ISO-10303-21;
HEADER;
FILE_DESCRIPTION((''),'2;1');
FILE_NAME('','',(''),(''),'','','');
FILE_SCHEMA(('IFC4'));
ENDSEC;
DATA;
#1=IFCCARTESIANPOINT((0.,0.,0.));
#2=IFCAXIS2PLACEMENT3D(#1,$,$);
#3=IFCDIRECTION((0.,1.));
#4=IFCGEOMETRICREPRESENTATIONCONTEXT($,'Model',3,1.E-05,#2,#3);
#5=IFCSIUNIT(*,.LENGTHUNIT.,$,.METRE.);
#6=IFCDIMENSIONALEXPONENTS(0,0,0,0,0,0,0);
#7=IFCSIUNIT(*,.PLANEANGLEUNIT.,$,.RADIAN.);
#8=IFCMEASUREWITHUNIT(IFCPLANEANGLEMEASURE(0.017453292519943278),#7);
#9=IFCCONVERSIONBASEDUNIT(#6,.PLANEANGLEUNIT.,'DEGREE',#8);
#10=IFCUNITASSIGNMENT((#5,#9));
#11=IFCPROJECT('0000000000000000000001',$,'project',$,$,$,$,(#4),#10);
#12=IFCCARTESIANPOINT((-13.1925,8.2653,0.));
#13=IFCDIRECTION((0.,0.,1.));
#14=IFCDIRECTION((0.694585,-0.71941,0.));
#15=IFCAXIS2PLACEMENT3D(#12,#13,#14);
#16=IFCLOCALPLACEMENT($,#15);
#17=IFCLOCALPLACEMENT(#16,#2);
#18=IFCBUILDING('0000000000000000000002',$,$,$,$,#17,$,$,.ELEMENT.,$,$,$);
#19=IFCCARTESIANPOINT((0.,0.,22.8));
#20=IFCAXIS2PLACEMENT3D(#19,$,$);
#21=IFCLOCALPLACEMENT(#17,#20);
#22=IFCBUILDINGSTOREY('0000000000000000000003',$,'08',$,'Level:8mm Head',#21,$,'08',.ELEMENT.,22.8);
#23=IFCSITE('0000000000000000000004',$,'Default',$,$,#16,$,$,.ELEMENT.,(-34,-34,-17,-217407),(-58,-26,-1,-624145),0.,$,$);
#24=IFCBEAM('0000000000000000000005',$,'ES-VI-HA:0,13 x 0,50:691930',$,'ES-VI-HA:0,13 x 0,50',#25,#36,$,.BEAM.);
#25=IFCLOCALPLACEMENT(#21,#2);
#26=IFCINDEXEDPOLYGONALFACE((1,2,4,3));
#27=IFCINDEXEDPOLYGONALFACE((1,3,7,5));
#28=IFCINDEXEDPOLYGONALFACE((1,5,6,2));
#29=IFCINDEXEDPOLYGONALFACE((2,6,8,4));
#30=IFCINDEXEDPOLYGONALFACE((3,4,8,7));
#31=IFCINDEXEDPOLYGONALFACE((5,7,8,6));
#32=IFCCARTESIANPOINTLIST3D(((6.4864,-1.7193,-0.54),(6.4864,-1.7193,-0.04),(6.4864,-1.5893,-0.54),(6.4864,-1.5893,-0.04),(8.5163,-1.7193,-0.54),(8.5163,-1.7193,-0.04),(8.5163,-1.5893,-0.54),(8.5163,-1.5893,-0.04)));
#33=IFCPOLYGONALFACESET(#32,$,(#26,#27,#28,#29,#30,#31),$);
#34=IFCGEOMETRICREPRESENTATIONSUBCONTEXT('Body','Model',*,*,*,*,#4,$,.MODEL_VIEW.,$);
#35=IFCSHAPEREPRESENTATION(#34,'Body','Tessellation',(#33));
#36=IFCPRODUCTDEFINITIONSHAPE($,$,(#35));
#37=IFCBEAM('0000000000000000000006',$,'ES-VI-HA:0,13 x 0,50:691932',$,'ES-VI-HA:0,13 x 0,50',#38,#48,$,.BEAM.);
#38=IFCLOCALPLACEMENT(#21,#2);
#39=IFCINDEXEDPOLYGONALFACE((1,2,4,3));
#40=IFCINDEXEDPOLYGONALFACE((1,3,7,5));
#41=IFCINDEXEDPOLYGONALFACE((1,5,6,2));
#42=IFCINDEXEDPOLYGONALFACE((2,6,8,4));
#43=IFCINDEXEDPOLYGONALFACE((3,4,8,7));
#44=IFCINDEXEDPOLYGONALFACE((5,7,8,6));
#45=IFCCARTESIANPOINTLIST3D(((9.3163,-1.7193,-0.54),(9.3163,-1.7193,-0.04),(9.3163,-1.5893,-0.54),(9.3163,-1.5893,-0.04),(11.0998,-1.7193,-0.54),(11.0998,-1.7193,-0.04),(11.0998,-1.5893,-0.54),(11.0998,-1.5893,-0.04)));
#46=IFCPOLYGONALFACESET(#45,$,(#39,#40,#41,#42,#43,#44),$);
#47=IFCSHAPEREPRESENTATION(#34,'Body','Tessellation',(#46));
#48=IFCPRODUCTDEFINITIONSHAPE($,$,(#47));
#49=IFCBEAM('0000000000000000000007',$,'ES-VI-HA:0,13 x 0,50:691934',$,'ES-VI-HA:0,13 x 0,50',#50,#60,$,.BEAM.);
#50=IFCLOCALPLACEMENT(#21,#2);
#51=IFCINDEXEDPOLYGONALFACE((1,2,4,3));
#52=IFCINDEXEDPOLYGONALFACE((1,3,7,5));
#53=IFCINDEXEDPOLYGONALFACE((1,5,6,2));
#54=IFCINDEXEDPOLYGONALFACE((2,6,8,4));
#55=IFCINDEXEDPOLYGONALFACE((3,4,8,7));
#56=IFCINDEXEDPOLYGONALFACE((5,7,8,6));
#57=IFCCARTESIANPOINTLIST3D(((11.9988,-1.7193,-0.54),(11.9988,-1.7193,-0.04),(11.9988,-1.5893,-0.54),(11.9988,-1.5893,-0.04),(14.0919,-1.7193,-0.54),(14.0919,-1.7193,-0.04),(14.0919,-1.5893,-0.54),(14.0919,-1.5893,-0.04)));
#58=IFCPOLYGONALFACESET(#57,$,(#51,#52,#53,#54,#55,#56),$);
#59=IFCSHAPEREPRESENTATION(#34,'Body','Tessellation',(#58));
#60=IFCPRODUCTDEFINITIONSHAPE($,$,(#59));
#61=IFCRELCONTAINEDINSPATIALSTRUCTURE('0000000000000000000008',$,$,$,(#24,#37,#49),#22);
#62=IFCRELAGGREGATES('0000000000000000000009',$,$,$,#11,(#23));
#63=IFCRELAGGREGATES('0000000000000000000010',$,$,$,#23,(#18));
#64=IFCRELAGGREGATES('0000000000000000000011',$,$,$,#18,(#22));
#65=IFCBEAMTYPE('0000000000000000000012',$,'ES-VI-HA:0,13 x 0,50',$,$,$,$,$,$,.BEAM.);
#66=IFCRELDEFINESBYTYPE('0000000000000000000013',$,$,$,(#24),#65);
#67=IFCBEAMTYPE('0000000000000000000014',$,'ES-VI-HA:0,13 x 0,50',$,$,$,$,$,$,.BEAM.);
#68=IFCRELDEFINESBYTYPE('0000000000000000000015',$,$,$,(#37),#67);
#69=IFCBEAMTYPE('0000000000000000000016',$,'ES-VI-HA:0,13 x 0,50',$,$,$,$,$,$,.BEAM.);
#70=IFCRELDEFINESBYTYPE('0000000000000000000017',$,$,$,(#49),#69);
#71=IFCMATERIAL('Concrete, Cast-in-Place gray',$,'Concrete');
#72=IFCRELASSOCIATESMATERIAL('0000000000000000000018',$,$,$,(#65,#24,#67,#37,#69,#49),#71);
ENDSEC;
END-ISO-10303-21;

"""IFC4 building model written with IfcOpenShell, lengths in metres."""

from ifc_helpers import new_model, entity, si_unit, converted_unit, direction, frame, origin, place, context, subcontext, project, spatial, indexed_curve, outline, extrude, source, transform, mapped, material, type_object, type_shapes, element, save


model = new_model("IFC4")

# Units and contexts
model_context = context("Model", 3, precision=1e-05, world=origin(), true_north=direction((0.0, 1.0)))
body_context = subcontext(model_context, "Body", "Model", "MODEL_VIEW")
ifc_project = project(units=[si_unit("LENGTHUNIT", "METRE"), converted_unit("PLANEANGLEUNIT", "DEGREE", entity("IfcPlaneAngleMeasure", 0.017453292519943278), si_unit("PLANEANGLEUNIT", "RADIAN"), dimensions=[0, 0, 0, 0, 0, 0, 0])], contexts=[model_context])

# Site, building, storey
site_placement = place(None, frame((-13.1925, 8.2653, 0.0), z_axis=(0.0, 0.0, 1.0), x_axis=(0.694585, -0.71941, 0.0)))
site = spatial("IfcSite", under=ifc_project, at=site_placement, Name="Default", CompositionType="ELEMENT", RefLatitude=(-34, -34, -17, -217407), RefLongitude=(-58, -26, -1, -624145), RefElevation=0.0)
building_placement = place(site_placement, origin())
building = spatial("IfcBuilding", under=site, at=building_placement, CompositionType="ELEMENT")
storey_placement = place(building_placement, frame((0.0, 0.0, 22.8)))
storey = spatial("IfcBuildingStorey", under=building, at=storey_placement, Name="08", ObjectType="Level:8mm Head", LongName="08", CompositionType="ELEMENT", Elevation=22.8)

# Beams
ifc_material_1 = material(Name="Concrete, Cast-in-Place gray", Category="Concrete")
beam_type_1 = type_object("IfcBeamType", Name="ES-VI-HA:0,13 x 0,50", PredefinedType="BEAM", material=ifc_material_1)
shared_shape_1 = source(origin(), body_context, "Body", "SweptSolid", [
    extrude(outline(indexed_curve([(-0.25, -0.065), (0.25, -0.065), (0.25, 0.065), (-0.25, 0.065), (-0.25, -0.065)], self_intersect=False)), frame((6.4864, -1.6543, 22.51), z_axis=(1.0, 0.0, 0.0), x_axis=(0.0, 0.0, -1.0)), (0.0, 0.0, 1.0), 2.0299),
])
type_shapes(beam_type_1, [shared_shape_1])
beam_1_placement = place(storey_placement, frame((0.0, 0.0, -22.8)))
element("IfcBeam", 1, at=beam_1_placement, inside=storey, type_object=beam_type_1, material=ifc_material_1, Name="ES-VI-HA:0,13 x 0,50:691930", ObjectType="ES-VI-HA:0,13 x 0,50", PredefinedType="BEAM", context=body_context, shape_type="MappedRepresentation", body=[
    mapped(shared_shape_1, transform((0.0, 0.0, 0.0), scale=1.0)),
])
beam_type_2 = type_object("IfcBeamType", Name="ES-VI-HA:0,13 x 0,50", PredefinedType="BEAM", material=ifc_material_1)
shared_shape_2 = source(origin(), body_context, "Body", "SweptSolid", [
    extrude(outline(indexed_curve([(-0.25, -0.065), (0.25, -0.065), (0.25, 0.065), (-0.25, 0.065), (-0.25, -0.065)], self_intersect=False)), frame((9.3163, -1.6543, 22.51), z_axis=(1.0, 0.0, 0.0), x_axis=(0.0, 0.0, -1.0)), (0.0, 0.0, 1.0), 1.7835),
])
type_shapes(beam_type_2, [shared_shape_2])
beam_2_placement = place(storey_placement, frame((0.0, 0.0, -22.8)))
element("IfcBeam", 2, at=beam_2_placement, inside=storey, type_object=beam_type_2, material=ifc_material_1, Name="ES-VI-HA:0,13 x 0,50:691932", ObjectType="ES-VI-HA:0,13 x 0,50", PredefinedType="BEAM", context=body_context, shape_type="MappedRepresentation", body=[
    mapped(shared_shape_2, transform((0.0, 0.0, 0.0), scale=1.0)),
])
beam_type_3 = type_object("IfcBeamType", Name="ES-VI-HA:0,13 x 0,50", PredefinedType="BEAM", material=ifc_material_1)
shared_shape_3 = source(origin(), body_context, "Body", "SweptSolid", [
    extrude(outline(indexed_curve([(-0.25, -0.065), (0.25, -0.065), (0.25, 0.065), (-0.25, 0.065), (-0.25, -0.065)], self_intersect=False)), frame((11.9988, -1.6543, 22.51), z_axis=(1.0, 0.0, 0.0), x_axis=(0.0, 0.0, -1.0)), (0.0, 0.0, 1.0), 2.0932),
])
type_shapes(beam_type_3, [shared_shape_3])
beam_3_placement = place(storey_placement, frame((0.0, 0.0, -22.8)))
element("IfcBeam", 3, at=beam_3_placement, inside=storey, type_object=beam_type_3, material=ifc_material_1, Name="ES-VI-HA:0,13 x 0,50:691934", ObjectType="ES-VI-HA:0,13 x 0,50", PredefinedType="BEAM", context=body_context, shape_type="MappedRepresentation", body=[
    mapped(shared_shape_3, transform((0.0, 0.0, 0.0), scale=1.0)),
])

save(model, "model.ifc")
